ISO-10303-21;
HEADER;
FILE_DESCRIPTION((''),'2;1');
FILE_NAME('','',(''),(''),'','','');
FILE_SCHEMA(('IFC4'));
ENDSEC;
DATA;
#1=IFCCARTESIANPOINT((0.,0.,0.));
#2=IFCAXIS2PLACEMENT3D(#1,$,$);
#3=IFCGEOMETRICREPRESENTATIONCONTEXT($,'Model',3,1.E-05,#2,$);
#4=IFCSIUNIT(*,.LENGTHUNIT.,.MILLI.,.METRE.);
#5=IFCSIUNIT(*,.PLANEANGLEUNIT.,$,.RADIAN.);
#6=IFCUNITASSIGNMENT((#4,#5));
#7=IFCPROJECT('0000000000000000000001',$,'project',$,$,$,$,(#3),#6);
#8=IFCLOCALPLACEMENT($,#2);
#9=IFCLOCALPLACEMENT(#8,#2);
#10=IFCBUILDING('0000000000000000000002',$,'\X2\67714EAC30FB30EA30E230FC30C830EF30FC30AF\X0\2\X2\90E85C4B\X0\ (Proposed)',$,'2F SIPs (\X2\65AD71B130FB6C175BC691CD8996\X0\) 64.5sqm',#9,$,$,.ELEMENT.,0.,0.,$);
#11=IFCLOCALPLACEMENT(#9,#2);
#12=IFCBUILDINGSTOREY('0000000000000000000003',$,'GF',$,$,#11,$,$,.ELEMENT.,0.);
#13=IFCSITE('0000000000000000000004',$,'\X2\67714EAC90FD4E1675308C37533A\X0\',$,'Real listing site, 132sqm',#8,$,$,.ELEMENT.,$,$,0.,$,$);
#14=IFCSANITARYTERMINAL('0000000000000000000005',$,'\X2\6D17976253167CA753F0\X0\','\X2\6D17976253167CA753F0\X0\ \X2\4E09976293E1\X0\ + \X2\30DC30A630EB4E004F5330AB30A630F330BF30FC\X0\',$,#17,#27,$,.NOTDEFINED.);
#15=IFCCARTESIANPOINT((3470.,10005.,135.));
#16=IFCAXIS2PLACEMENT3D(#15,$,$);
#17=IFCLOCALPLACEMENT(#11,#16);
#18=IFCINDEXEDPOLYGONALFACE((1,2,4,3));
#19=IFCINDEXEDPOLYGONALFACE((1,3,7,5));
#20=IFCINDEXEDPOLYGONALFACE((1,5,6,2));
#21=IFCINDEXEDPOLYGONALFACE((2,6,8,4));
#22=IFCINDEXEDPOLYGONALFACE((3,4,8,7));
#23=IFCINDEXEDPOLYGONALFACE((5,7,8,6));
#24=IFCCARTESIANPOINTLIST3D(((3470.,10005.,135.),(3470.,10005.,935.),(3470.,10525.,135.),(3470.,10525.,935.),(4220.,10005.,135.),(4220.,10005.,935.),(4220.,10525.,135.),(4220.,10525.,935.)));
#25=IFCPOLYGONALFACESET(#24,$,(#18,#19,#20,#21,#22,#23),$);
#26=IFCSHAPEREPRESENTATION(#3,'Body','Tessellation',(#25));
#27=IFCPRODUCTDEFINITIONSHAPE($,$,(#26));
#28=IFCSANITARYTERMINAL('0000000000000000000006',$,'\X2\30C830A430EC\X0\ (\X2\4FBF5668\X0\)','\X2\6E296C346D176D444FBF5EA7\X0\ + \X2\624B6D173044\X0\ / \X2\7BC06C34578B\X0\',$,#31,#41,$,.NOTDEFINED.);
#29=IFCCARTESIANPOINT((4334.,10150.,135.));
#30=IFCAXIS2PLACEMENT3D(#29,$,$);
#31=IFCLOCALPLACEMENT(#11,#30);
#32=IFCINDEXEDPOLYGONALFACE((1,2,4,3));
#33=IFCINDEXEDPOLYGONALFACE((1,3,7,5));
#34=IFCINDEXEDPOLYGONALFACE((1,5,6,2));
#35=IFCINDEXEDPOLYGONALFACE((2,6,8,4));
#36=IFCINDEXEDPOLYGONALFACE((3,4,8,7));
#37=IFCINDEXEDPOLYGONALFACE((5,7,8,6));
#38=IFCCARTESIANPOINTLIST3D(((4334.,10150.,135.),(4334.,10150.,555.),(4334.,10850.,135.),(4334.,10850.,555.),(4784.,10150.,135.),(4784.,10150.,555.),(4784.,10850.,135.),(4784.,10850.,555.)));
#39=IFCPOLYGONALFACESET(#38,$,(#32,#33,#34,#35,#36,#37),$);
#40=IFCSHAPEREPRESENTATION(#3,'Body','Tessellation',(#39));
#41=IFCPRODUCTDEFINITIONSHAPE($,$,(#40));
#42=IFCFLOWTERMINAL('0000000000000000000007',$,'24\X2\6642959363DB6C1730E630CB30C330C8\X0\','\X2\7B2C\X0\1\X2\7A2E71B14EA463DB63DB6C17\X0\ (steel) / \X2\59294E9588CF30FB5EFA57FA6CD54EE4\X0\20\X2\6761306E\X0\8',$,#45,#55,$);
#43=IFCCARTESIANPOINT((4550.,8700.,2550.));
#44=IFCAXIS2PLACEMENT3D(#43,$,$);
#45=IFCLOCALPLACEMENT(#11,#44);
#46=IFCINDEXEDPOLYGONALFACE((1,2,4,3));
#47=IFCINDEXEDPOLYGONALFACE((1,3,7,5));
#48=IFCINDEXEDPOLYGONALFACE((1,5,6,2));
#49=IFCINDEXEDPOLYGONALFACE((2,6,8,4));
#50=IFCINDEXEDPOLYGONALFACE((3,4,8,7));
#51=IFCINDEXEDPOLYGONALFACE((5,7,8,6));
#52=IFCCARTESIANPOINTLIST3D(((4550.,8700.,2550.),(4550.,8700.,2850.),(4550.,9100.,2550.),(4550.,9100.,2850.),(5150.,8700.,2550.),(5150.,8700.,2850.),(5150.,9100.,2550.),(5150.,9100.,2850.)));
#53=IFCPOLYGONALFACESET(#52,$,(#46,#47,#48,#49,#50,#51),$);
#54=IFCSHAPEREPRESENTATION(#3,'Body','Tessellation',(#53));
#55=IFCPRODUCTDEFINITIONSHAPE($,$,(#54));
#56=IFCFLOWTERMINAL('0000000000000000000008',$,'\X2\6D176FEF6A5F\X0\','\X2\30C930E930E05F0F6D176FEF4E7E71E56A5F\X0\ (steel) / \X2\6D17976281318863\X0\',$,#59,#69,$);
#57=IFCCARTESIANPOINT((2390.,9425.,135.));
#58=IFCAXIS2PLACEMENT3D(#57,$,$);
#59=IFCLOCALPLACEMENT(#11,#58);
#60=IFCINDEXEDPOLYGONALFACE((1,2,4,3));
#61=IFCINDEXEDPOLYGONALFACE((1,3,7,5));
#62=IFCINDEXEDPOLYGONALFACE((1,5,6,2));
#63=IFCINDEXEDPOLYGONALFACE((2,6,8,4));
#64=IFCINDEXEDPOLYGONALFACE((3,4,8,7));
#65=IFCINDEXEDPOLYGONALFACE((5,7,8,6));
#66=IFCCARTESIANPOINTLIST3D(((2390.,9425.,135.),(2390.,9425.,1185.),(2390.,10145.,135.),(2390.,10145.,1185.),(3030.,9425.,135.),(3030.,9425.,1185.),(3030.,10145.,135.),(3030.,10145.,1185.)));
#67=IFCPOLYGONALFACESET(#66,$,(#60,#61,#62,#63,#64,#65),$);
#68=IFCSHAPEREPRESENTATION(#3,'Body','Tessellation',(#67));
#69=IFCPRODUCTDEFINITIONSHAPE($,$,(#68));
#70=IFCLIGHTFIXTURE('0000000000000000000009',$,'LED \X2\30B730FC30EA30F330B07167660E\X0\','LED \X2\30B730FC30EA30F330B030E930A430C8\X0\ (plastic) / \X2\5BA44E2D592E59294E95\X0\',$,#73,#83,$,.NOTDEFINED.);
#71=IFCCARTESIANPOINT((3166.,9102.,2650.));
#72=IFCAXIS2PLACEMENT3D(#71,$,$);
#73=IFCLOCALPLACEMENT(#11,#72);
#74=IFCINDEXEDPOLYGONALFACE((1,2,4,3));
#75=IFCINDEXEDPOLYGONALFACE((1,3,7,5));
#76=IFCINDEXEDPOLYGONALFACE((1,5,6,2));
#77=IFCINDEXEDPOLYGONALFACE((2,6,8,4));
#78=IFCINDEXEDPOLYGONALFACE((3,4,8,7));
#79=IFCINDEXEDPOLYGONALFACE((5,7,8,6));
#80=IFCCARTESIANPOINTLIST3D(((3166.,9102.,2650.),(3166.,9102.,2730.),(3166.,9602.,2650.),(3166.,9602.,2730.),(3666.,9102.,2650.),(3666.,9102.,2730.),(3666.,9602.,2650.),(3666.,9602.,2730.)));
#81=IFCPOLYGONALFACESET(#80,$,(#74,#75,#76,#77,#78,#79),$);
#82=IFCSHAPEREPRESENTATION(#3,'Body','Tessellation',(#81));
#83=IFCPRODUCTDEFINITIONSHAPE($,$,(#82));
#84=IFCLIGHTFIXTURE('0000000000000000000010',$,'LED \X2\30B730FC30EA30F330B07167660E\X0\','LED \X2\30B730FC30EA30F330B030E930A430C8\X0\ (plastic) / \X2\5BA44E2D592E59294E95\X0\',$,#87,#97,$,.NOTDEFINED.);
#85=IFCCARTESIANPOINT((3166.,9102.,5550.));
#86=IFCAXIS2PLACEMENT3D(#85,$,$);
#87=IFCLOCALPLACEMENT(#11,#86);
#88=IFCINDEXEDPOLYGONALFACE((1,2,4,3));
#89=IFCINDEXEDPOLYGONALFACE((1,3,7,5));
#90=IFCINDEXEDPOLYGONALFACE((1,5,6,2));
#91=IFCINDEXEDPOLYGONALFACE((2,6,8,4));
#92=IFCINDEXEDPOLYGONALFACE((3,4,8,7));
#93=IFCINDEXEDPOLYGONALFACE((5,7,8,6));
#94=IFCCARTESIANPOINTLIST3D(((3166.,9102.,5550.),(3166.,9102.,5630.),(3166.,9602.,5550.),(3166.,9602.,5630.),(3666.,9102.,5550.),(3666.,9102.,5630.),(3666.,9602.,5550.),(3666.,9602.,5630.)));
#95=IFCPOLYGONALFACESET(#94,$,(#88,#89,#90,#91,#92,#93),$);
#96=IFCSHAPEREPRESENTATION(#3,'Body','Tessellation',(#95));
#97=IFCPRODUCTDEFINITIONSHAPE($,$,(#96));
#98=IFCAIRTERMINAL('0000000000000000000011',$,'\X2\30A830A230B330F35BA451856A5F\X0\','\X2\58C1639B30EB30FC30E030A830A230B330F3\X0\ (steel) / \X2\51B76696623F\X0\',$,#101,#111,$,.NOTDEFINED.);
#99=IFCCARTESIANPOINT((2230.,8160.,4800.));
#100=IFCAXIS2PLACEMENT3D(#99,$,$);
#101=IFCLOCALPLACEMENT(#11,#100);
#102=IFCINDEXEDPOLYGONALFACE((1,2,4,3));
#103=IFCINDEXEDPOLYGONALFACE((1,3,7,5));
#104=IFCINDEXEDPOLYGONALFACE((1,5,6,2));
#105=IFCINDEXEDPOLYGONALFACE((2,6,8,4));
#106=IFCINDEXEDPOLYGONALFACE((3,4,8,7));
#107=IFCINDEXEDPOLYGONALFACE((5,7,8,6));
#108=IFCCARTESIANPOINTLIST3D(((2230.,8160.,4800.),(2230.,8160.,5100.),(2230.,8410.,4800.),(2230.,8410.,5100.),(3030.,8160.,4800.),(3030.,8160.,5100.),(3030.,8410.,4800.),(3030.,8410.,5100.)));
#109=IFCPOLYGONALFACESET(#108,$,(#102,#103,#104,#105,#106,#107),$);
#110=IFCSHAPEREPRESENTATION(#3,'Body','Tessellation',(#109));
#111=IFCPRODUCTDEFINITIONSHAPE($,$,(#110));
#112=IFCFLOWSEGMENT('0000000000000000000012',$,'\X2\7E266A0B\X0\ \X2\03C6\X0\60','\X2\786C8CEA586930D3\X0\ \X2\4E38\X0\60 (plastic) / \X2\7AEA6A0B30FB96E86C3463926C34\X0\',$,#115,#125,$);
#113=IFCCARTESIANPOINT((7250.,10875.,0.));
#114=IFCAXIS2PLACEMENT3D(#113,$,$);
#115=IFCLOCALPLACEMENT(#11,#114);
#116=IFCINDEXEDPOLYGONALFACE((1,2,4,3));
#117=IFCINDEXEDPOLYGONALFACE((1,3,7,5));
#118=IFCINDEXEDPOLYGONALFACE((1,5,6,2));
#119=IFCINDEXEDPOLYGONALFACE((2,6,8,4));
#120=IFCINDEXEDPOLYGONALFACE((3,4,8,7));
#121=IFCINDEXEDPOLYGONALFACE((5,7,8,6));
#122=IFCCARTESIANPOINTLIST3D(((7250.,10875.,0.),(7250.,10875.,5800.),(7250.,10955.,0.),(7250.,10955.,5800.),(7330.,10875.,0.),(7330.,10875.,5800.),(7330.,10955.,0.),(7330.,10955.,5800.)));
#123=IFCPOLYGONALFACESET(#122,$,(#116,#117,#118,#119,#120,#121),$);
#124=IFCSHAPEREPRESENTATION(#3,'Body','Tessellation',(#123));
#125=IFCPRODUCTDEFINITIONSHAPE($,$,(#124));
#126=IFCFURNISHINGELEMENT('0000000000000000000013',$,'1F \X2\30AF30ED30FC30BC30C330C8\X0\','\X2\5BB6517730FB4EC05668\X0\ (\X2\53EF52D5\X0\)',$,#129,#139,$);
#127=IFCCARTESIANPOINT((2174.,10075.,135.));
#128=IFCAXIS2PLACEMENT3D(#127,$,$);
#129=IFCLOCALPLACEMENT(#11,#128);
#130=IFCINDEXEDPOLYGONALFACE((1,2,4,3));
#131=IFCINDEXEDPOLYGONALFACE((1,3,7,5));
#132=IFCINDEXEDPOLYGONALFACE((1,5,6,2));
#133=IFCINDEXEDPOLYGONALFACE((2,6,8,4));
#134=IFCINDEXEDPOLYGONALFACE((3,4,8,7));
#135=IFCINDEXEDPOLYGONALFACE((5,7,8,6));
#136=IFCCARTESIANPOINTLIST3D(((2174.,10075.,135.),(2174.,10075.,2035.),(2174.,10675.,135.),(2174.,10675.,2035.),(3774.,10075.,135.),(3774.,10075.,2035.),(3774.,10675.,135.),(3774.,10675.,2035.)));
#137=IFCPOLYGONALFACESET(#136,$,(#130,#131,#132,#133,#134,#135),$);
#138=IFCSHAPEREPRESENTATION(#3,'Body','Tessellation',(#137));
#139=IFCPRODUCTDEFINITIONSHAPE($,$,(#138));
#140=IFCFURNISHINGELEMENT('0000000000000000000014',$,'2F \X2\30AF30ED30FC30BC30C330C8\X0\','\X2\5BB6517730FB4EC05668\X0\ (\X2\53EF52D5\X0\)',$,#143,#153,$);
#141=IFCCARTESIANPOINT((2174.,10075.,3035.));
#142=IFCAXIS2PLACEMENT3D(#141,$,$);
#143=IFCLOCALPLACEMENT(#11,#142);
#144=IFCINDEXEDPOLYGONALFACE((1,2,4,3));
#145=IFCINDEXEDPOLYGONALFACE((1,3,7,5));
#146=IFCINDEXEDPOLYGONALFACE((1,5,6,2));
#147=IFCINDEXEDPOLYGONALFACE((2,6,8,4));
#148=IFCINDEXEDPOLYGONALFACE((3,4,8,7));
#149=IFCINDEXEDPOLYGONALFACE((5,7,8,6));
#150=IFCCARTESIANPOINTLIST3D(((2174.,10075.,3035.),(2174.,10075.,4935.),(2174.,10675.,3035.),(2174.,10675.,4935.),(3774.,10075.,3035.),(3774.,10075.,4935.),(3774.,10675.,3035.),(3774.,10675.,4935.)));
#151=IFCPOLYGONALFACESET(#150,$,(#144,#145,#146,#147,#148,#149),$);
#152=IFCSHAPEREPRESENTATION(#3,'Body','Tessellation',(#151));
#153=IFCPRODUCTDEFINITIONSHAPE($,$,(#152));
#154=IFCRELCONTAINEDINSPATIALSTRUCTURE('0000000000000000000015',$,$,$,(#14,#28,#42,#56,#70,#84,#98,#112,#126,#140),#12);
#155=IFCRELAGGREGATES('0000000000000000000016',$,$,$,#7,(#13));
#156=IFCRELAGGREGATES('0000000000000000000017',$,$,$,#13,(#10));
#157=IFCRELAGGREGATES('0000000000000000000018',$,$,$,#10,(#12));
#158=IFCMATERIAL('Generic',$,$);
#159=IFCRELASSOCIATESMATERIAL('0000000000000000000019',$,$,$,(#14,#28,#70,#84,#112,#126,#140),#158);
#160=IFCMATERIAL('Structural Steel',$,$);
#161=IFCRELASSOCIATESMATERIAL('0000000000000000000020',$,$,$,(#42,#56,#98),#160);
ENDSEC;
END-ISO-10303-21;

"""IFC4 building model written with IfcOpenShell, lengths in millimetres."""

from ifc_helpers import new_model, si_unit, frame, frame_2d, origin, place, context, project, spatial, rectangle, extrude, material, element, save


model = new_model("IFC4")

# Units and contexts
model_context = context("Model", 3, precision=1e-05, world=origin())
ifc_project = project(units=[si_unit("LENGTHUNIT", "METRE", prefix="MILLI"), si_unit("PLANEANGLEUNIT", "RADIAN")], contexts=[model_context])

# Site, building, storey
site_placement = place(None, origin())
site = spatial("IfcSite", under=ifc_project, at=site_placement, Name="東京都世田谷区", ObjectType="Real listing site, 132sqm", CompositionType="ELEMENT", RefElevation=0.0)
building_placement = place(site_placement, origin())
building = spatial("IfcBuilding", under=site, at=building_placement, Name="東京・リモートワーク2部屋 (Proposed)", ObjectType="2F SIPs (断熱・気密重視) 64.5sqm", CompositionType="ELEMENT", ElevationOfRefHeight=0.0, ElevationOfTerrain=0.0)
storey_placement = place(building_placement, origin())
storey = spatial("IfcBuildingStorey", under=building, at=storey_placement, Name="GF", CompositionType="ELEMENT", Elevation=0.0)

# Sanitary terminals
ifc_material_1 = material(Name="Generic")
sanitary_terminal_1_placement = place(storey_placement, frame((3470.0, 10005.0, 135.0)))
element("IfcSanitaryTerminal", 1, at=sanitary_terminal_1_placement, inside=storey, material=ifc_material_1, Name="洗面化粧台", Description="洗面化粧台 三面鏡 + ボウル一体カウンター", PredefinedType="NOTDEFINED", context=model_context, shape_type="SweptSolid", body=[
    extrude(rectangle(XDim=750.0, YDim=520.0, at=frame_2d((375.0, 260.0))), frame((3470.0, 10005.0, 135.0)), (0.0, 0.0, 1.0), 800.0),
])
sanitary_terminal_2_placement = place(storey_placement, frame((4334.0, 10150.0, 135.0)))
element("IfcSanitaryTerminal", 2, at=sanitary_terminal_2_placement, inside=storey, material=ifc_material_1, Name="トイレ (便器)", Description="温水洗浄便座 + 手洗い / 節水型", PredefinedType="NOTDEFINED", context=model_context, shape_type="SweptSolid", body=[
    extrude(rectangle(XDim=450.0, YDim=700.0, at=frame_2d((225.0, 350.0))), frame((4334.0, 10150.0, 135.0)), (0.0, 0.0, 1.0), 420.0),
])

# Flow terminals
ifc_material_2 = material(Name="Structural Steel")
flow_terminal_1_placement = place(storey_placement, frame((4550.0, 8700.0, 2550.0)))
element("IfcFlowTerminal", 3, at=flow_terminal_1_placement, inside=storey, material=ifc_material_2, Name="24時間換気ユニット", Description="第1種熱交換換気 (steel) / 天井裏・建基法令20条の8", context=model_context, shape_type="SweptSolid", body=[
    extrude(rectangle(XDim=600.0, YDim=400.0, at=frame_2d((300.0, 200.0))), frame((4550.0, 8700.0, 2550.0)), (0.0, 0.0, 1.0), 300.0),
])
flow_terminal_2_placement = place(storey_placement, frame((2390.0, 9425.0, 135.0)))
element("IfcFlowTerminal", 4, at=flow_terminal_2_placement, inside=storey, material=ifc_material_2, Name="洗濯機", Description="ドラム式洗濯乾燥機 (steel) / 洗面脱衣", context=model_context, shape_type="SweptSolid", body=[
    extrude(rectangle(XDim=640.0, YDim=720.0, at=frame_2d((320.0, 360.0))), frame((2390.0, 9425.0, 135.0)), (0.0, 0.0, 1.0), 1050.0),
])

# Light fixtures
light_fixture_1_placement = place(storey_placement, frame((3166.0, 9102.0, 2650.0)))
element("IfcLightFixture", 5, at=light_fixture_1_placement, inside=storey, material=ifc_material_1, Name="LED シーリング照明", Description="LED シーリングライト (plastic) / 室中央天井", PredefinedType="NOTDEFINED", context=model_context, shape_type="SweptSolid", body=[
    extrude(rectangle(XDim=500.0, YDim=500.0, at=frame_2d((250.0, 250.0))), frame((3166.0, 9102.0, 2650.0)), (0.0, 0.0, 1.0), 80.0),
])
light_fixture_2_placement = place(storey_placement, frame((3166.0, 9102.0, 5550.0)))
element("IfcLightFixture", 6, at=light_fixture_2_placement, inside=storey, material=ifc_material_1, Name="LED シーリング照明", Description="LED シーリングライト (plastic) / 室中央天井", PredefinedType="NOTDEFINED", context=model_context, shape_type="SweptSolid", body=[
    extrude(rectangle(XDim=500.0, YDim=500.0, at=frame_2d((250.0, 250.0))), frame((3166.0, 9102.0, 5550.0)), (0.0, 0.0, 1.0), 80.0),
])

# Air terminal
air_terminal_placement = place(storey_placement, frame((2230.0, 8160.0, 4800.0)))
element("IfcAirTerminal", 7, at=air_terminal_placement, inside=storey, material=ifc_material_2, Name="エアコン室内機", Description="壁掛ルームエアコン (steel) / 冷暖房", PredefinedType="NOTDEFINED", context=model_context, shape_type="SweptSolid", body=[
    extrude(rectangle(XDim=800.0, YDim=250.0, at=frame_2d((400.0, 125.0))), frame((2230.0, 8160.0, 4800.0)), (0.0, 0.0, 1.0), 300.0),
])

# Flow segment
flow_segment_placement = place(storey_placement, frame((7250.0, 10875.0, 0.0)))
element("IfcFlowSegment", 8, at=flow_segment_placement, inside=storey, material=ifc_material_1, Name="縦樋 φ60", Description="硬質塩ビ 丸60 (plastic) / 竪樋・雨水排水", context=model_context, shape_type="SweptSolid", body=[
    extrude(rectangle(XDim=80.0, YDim=80.0, at=frame_2d((40.0, 40.0))), frame((7250.0, 10875.0, 0.0)), (0.0, 0.0, 1.0), 5800.0),
])

# Furnishing elements
furnishing_1_placement = place(storey_placement, frame((2174.0, 10075.0, 135.0)))
element("IfcFurnishingElement", 9, at=furnishing_1_placement, inside=storey, material=ifc_material_1, Name="1F クローゼット", Description="家具・什器 (可動)", context=model_context, shape_type="SweptSolid", body=[
    extrude(rectangle(XDim=1600.0, YDim=600.0, at=frame_2d((800.0, 300.0))), frame((2174.0, 10075.0, 135.0)), (0.0, 0.0, 1.0), 1900.0),
])
furnishing_2_placement = place(storey_placement, frame((2174.0, 10075.0, 3035.0)))
element("IfcFurnishingElement", 10, at=furnishing_2_placement, inside=storey, material=ifc_material_1, Name="2F クローゼット", Description="家具・什器 (可動)", context=model_context, shape_type="SweptSolid", body=[
    extrude(rectangle(XDim=1600.0, YDim=600.0, at=frame_2d((800.0, 300.0))), frame((2174.0, 10075.0, 3035.0)), (0.0, 0.0, 1.0), 1900.0),
])

save(model, "model.ifc")
